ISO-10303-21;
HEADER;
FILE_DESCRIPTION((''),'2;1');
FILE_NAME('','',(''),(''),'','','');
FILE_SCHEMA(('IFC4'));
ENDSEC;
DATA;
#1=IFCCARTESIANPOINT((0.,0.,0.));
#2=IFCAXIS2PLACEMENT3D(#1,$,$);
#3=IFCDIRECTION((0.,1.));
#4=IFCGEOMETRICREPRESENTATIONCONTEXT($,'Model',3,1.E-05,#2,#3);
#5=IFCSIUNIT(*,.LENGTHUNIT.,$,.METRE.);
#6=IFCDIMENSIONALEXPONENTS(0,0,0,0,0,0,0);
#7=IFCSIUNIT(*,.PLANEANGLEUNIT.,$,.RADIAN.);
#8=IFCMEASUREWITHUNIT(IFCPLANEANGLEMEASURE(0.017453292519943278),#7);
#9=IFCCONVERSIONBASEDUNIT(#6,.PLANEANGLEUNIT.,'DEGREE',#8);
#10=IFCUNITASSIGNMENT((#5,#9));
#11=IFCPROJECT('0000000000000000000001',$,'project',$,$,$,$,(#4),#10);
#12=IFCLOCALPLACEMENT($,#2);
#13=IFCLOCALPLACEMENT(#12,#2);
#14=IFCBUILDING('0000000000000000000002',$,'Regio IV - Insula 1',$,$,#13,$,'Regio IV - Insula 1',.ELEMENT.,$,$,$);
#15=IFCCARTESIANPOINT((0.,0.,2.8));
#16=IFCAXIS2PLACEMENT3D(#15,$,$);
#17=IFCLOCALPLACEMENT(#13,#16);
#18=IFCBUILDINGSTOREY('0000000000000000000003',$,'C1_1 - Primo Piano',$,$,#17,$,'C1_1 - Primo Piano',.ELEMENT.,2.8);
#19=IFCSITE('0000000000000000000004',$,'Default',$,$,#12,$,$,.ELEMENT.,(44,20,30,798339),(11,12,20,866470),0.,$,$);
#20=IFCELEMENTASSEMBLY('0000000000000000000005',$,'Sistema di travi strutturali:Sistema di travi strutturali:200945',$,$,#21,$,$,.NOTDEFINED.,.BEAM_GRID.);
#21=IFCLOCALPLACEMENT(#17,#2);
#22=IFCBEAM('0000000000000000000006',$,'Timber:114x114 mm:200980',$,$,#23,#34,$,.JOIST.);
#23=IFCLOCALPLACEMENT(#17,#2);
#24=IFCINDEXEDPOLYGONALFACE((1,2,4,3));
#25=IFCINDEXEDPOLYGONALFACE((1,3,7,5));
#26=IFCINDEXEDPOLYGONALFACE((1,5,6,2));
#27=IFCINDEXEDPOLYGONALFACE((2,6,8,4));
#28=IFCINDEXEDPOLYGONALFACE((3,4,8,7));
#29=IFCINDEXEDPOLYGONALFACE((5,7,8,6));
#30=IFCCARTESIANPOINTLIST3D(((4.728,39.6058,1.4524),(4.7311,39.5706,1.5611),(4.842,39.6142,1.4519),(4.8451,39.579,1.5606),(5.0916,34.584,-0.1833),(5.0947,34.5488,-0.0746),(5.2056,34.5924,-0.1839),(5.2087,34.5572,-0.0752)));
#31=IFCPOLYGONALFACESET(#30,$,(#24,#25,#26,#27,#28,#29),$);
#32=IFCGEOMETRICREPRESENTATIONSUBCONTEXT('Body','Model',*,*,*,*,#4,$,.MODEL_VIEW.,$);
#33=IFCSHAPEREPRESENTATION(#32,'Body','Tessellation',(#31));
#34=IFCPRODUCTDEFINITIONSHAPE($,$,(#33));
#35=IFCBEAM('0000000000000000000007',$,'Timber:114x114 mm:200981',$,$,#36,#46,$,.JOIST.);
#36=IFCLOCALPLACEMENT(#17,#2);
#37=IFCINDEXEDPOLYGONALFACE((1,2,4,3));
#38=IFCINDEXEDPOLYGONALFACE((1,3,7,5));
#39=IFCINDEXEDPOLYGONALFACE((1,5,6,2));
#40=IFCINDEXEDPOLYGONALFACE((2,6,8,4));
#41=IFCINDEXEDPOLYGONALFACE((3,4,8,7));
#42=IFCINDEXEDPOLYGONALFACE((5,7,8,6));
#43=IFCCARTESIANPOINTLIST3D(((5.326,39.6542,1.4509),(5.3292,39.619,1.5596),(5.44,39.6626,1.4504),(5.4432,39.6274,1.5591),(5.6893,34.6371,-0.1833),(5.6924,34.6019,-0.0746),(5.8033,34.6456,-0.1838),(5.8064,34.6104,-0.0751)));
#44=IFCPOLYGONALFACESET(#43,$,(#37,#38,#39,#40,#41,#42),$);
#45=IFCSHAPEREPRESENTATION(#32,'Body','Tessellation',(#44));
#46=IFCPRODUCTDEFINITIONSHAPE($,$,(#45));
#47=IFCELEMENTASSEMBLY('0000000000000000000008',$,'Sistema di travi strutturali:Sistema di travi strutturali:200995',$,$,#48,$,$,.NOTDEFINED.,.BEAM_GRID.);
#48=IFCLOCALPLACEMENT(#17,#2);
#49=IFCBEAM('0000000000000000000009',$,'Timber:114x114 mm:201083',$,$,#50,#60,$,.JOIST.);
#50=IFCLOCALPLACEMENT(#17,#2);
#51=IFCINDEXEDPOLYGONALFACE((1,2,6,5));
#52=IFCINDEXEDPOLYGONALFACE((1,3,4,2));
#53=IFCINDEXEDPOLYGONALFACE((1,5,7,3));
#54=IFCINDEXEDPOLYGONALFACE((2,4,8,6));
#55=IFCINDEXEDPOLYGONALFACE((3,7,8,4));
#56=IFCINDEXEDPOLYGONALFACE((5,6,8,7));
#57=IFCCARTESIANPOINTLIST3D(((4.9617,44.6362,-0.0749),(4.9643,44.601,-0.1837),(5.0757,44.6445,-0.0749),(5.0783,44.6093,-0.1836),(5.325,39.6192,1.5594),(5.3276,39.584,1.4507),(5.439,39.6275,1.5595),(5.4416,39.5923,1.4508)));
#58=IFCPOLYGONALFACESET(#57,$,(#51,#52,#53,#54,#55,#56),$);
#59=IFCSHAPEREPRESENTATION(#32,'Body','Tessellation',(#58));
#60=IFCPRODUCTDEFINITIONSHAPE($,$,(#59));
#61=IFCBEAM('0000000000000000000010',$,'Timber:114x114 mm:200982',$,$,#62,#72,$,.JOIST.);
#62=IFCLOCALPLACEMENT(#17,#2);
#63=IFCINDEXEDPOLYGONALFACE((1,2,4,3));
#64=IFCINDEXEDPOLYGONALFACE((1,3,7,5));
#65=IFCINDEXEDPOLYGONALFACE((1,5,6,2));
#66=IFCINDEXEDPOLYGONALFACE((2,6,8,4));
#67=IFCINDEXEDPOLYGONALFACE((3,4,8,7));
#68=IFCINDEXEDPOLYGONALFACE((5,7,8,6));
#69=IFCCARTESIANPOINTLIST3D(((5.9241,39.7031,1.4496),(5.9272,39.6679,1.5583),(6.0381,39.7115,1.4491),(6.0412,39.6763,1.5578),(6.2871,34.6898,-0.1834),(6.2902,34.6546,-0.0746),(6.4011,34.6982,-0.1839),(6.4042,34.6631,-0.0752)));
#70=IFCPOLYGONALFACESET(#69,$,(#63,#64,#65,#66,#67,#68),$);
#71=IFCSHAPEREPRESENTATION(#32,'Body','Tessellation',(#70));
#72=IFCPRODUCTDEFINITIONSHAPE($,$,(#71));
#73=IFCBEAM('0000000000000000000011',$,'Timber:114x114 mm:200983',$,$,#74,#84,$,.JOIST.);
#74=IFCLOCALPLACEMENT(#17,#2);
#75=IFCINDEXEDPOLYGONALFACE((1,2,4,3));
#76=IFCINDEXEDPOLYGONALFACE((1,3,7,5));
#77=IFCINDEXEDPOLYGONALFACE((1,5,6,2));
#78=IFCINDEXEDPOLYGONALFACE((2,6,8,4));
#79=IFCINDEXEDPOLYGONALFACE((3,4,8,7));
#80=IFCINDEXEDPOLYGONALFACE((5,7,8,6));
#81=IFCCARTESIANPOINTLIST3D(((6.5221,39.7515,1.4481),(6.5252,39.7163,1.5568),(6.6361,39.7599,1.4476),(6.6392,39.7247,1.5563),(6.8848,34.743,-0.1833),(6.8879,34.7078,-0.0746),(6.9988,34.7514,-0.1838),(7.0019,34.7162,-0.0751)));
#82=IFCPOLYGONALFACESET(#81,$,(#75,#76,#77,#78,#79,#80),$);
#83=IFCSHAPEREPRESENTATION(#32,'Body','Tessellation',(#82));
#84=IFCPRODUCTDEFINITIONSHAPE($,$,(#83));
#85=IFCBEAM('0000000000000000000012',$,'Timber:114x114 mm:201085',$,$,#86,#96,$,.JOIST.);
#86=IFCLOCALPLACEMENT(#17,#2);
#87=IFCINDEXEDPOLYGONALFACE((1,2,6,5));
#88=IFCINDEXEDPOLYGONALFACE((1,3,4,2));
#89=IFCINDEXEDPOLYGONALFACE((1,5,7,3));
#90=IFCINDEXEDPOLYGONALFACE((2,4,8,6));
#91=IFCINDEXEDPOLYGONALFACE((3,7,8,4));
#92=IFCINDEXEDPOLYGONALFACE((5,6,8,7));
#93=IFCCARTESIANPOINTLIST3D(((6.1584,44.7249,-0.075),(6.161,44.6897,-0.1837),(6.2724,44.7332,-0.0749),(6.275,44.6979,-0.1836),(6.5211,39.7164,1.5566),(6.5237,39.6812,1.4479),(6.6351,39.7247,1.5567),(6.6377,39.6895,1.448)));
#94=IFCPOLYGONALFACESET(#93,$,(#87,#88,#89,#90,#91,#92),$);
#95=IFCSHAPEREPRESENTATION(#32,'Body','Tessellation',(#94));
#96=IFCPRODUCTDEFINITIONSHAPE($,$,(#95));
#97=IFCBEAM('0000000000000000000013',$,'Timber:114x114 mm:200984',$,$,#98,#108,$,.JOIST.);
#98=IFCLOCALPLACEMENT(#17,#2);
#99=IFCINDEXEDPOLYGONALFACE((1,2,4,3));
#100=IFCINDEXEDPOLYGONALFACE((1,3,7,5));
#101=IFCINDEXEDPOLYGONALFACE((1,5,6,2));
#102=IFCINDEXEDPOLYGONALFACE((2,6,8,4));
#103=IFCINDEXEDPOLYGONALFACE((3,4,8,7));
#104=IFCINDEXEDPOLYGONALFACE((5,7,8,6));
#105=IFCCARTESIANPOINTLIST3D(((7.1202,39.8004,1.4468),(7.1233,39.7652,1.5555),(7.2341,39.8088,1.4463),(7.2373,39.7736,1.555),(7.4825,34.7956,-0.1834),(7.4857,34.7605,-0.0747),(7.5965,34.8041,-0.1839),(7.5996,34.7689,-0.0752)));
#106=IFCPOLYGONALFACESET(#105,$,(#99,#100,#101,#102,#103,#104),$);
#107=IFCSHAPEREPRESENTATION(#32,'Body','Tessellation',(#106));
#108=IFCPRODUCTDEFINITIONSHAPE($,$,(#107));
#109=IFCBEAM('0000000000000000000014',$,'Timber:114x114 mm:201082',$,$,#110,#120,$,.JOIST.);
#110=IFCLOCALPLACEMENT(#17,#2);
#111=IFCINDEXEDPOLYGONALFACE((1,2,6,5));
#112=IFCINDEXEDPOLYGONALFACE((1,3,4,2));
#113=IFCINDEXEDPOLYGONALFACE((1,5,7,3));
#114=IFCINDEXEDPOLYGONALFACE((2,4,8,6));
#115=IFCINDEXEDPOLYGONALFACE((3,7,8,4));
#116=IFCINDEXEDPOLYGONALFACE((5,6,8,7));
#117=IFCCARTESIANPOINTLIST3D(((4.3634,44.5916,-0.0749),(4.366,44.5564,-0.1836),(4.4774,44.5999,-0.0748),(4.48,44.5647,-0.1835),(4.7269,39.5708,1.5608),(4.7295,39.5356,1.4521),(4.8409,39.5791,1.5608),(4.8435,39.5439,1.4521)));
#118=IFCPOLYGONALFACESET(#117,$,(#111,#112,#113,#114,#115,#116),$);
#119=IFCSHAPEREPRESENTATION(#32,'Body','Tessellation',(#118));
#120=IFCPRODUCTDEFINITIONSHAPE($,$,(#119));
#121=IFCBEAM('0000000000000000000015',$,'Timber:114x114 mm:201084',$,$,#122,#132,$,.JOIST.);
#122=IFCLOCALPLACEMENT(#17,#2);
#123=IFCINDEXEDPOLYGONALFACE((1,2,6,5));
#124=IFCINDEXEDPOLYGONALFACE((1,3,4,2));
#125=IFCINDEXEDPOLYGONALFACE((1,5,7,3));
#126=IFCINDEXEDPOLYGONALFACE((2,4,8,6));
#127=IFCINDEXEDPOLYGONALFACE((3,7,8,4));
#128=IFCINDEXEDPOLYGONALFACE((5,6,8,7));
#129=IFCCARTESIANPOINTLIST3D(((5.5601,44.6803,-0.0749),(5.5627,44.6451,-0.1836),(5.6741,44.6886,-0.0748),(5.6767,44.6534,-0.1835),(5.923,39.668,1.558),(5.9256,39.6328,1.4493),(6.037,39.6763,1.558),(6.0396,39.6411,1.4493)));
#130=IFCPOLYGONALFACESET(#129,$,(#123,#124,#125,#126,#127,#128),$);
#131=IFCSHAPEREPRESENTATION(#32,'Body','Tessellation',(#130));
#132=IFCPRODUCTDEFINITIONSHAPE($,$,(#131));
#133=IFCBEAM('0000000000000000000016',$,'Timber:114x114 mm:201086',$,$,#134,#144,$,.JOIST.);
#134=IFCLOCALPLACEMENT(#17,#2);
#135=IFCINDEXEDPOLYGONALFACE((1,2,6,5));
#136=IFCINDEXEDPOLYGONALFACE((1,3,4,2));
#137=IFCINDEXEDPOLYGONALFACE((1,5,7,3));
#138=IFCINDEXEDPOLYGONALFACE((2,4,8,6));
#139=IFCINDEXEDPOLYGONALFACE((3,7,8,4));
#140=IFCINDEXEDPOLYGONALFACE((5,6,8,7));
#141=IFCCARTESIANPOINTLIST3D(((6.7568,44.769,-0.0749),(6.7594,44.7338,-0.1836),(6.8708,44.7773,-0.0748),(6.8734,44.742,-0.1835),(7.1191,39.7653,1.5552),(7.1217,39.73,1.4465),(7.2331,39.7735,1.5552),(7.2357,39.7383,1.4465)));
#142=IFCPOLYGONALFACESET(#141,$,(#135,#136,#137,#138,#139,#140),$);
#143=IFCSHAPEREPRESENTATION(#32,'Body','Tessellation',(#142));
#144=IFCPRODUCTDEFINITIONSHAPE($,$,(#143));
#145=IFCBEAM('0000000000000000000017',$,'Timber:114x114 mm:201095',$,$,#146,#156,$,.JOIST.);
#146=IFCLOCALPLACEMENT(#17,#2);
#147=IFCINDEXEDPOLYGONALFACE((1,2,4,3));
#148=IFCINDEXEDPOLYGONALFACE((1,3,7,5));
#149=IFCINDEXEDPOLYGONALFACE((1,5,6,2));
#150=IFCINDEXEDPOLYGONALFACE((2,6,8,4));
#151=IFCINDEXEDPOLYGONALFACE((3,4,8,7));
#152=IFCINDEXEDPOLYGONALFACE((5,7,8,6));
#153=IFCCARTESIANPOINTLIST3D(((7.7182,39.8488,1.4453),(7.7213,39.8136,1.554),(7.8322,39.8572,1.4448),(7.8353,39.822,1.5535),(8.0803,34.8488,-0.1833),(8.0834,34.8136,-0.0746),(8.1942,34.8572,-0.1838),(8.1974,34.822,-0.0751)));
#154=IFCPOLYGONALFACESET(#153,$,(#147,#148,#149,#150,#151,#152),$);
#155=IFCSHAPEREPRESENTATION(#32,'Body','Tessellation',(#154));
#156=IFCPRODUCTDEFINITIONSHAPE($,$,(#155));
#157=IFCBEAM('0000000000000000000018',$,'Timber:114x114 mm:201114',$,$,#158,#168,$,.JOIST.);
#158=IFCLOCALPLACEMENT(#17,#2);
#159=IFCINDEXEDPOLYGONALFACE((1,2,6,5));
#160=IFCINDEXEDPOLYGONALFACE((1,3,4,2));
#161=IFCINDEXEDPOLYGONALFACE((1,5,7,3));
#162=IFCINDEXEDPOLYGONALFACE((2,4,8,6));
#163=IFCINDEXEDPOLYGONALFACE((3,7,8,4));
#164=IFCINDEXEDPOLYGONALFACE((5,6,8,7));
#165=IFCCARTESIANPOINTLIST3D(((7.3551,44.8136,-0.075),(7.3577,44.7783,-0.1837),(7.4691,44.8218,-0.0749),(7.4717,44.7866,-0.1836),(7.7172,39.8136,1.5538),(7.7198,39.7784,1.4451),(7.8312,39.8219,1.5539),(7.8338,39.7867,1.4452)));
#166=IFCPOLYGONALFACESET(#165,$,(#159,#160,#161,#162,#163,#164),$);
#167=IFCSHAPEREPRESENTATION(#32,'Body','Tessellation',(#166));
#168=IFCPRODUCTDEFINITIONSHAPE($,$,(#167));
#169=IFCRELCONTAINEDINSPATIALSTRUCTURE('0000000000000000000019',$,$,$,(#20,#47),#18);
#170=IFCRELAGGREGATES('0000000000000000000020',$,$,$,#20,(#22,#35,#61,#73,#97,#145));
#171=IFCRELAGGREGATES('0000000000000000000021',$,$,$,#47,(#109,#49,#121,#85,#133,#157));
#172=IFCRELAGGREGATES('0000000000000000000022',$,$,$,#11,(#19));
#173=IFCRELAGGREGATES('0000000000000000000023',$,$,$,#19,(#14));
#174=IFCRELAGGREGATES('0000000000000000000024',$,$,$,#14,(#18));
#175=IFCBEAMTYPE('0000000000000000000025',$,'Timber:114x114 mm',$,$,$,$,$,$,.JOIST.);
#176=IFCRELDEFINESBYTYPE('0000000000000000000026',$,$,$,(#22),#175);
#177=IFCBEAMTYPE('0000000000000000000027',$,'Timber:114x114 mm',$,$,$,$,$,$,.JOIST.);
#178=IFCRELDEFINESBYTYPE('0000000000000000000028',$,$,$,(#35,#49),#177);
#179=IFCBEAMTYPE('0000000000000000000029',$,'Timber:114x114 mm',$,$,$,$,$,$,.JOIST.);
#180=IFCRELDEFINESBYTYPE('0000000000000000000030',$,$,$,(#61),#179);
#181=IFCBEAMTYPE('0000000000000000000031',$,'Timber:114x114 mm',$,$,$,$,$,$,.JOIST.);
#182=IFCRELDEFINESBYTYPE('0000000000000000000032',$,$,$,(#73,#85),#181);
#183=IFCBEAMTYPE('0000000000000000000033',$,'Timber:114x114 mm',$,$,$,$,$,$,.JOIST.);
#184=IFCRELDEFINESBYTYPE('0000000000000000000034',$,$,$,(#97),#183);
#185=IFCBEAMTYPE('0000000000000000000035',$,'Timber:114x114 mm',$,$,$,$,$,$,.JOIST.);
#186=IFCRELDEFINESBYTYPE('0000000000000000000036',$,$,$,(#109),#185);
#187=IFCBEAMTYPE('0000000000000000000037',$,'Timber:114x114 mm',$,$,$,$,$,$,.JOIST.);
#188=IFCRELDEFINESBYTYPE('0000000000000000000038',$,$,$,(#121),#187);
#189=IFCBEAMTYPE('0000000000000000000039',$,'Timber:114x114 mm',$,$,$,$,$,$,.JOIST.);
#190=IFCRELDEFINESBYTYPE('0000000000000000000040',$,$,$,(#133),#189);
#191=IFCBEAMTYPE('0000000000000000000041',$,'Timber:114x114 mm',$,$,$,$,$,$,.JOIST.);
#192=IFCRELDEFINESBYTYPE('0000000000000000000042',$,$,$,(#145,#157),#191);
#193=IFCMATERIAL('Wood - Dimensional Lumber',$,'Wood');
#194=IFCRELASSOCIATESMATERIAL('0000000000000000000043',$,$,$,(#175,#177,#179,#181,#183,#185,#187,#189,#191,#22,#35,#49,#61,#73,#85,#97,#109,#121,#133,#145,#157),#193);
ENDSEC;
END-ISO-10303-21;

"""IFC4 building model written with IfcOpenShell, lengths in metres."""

from ifc_helpers import new_model, entity, si_unit, converted_unit, direction, frame, origin, origin_2d_with_axis, place, context, subcontext, project, spatial, rectangle, extrude, source, transform, mapped, material, material_profile, profile_set, profile_usage, type_object, type_shapes, element, aggregate, save


model = new_model("IFC4")

# Units and contexts
model_context = context("Model", 3, precision=1e-05, world=origin(), true_north=direction((0.0, 1.0)))
body_context = subcontext(model_context, "Body", "Model", "MODEL_VIEW")
ifc_project = project(units=[si_unit("LENGTHUNIT", "METRE"), converted_unit("PLANEANGLEUNIT", "DEGREE", entity("IfcPlaneAngleMeasure", 0.017453292519943278), si_unit("PLANEANGLEUNIT", "RADIAN"), dimensions=[0, 0, 0, 0, 0, 0, 0])], contexts=[model_context])

# Site, building, storey
site_placement = place(None, origin())
site = spatial("IfcSite", under=ifc_project, at=site_placement, Name="Default", CompositionType="ELEMENT", RefLatitude=(44, 20, 30, 798339), RefLongitude=(11, 12, 20, 866470), RefElevation=0.0)
building_placement = place(site_placement, origin())
building = spatial("IfcBuilding", under=site, at=building_placement, Name="Regio IV - Insula 1", LongName="Regio IV - Insula 1", CompositionType="ELEMENT")
storey_placement = place(building_placement, frame((0.0, 0.0, 2.8)))
storey = spatial("IfcBuildingStorey", under=building, at=storey_placement, Name="C1_1 - Primo Piano", LongName="C1_1 - Primo Piano", CompositionType="ELEMENT", Elevation=2.8)

# Element assembly, beams
assembly_1_placement = place(storey_placement, origin())
assembly_1 = element("IfcElementAssembly", 1, at=assembly_1_placement, inside=storey, Name="Sistema di travi strutturali:Sistema di travi strutturali:200945", AssemblyPlace="NOTDEFINED", PredefinedType="BEAM_GRID")
ifc_material = material(Name="Wood - Dimensional Lumber", Category="Wood")
ifc_material_profile = material_profile(ifc_material, rectangle(XDim=5.294, YDim=0.1143, at=origin_2d_with_axis()), Name="114x114 mm")
ifc_profile_set = profile_set([ifc_material_profile], Name="114x114 mm")
ifc_profile_usage = profile_usage(ifc_profile_set, cardinal=8)
beam_type_1 = type_object("IfcBeamType", Name="Timber:114x114 mm", PredefinedType="JOIST", material=ifc_profile_set)
shared_shape_1 = source(origin(), body_context, "Body", "SweptSolid", [
    extrude(rectangle(XDim=5.294, YDim=0.1143, at=origin_2d_with_axis()), frame((0.0, 0.0, -0.0572), z_axis=(0.0, 0.0, 1.0), x_axis=(-1.0, 0.0, 0.0)), (0.0, 0.0, 1.0), 0.1143),
])
type_shapes(beam_type_1, [shared_shape_1])
beam_1_placement = place(assembly_1_placement, frame((4.9684, 37.0815, 0.6886), z_axis=(0.027263, -0.307812, 0.951057), x_axis=(0.068686, -0.948585, -0.308981)))
beam_1 = element("IfcBeam", 2, at=beam_1_placement, type_object=beam_type_1, material=ifc_profile_usage, Name="Timber:114x114 mm:200980", PredefinedType="JOIST", context=body_context, shape_type="MappedRepresentation", body=[
    mapped(shared_shape_1, transform((0.0, 0.0, 0.0), scale=1.0)),
])
beam_type_2 = type_object("IfcBeamType", Name="Timber:114x114 mm", PredefinedType="JOIST", material=ifc_profile_set)
shared_shape_2 = source(origin(), body_context, "Body", "SweptSolid", [
    extrude(rectangle(XDim=5.289, YDim=0.1143, at=origin_2d_with_axis()), frame((0.0, 0.0, -0.0572), z_axis=(0.0, 0.0, 1.0), x_axis=(-1.0, 0.0, 0.0)), (0.0, 0.0, 1.0), 0.1143),
])
type_shapes(beam_type_2, [shared_shape_2])
beam_2_placement = place(assembly_1_placement, frame((5.5662, 37.1323, 0.6879), z_axis=(0.027263, -0.307812, 0.951057), x_axis=(0.068686, -0.948585, -0.308981)))
beam_2 = element("IfcBeam", 3, at=beam_2_placement, type_object=beam_type_2, material=ifc_profile_usage, Name="Timber:114x114 mm:200981", PredefinedType="JOIST", context=body_context, shape_type="MappedRepresentation", body=[
    mapped(shared_shape_2, transform((0.0, 0.0, 0.0), scale=1.0)),
])

# Element assembly, beam
assembly_2_placement = place(storey_placement, origin())
assembly_2 = element("IfcElementAssembly", 4, at=assembly_2_placement, inside=storey, Name="Sistema di travi strutturali:Sistema di travi strutturali:200995", AssemblyPlace="NOTDEFINED", PredefinedType="BEAM_GRID")
beam_3_placement = place(assembly_2_placement, frame((5.2016, 42.1142, 0.6879), z_axis=(-0.022823, 0.308173, 0.951057), x_axis=(0.068685, -0.948573, 0.309017)))
beam_3 = element("IfcBeam", 5, at=beam_3_placement, type_object=beam_type_2, material=ifc_profile_usage, Name="Timber:114x114 mm:201083", PredefinedType="JOIST", context=body_context, shape_type="MappedRepresentation", body=[
    mapped(shared_shape_2, transform((0.0, 0.0, 0.0), scale=1.0)),
])

# Beams
beam_type_3 = type_object("IfcBeamType", Name="Timber:114x114 mm", PredefinedType="JOIST", material=ifc_profile_set)
shared_shape_3 = source(origin(), body_context, "Body", "SweptSolid", [
    extrude(rectangle(XDim=5.285, YDim=0.1143, at=origin_2d_with_axis()), frame((0.0, 0.0, -0.0572), z_axis=(0.0, 0.0, 1.0), x_axis=(-1.0, 0.0, 0.0)), (0.0, 0.0, 1.0), 0.1143),
])
type_shapes(beam_type_3, [shared_shape_3])
beam_4_placement = place(assembly_1_placement, frame((6.1641, 37.1831, 0.6872), z_axis=(0.027263, -0.307812, 0.951057), x_axis=(0.068686, -0.948585, -0.308981)))
beam_4 = element("IfcBeam", 6, at=beam_4_placement, type_object=beam_type_3, material=ifc_profile_usage, Name="Timber:114x114 mm:200982", PredefinedType="JOIST", context=body_context, shape_type="MappedRepresentation", body=[
    mapped(shared_shape_3, transform((0.0, 0.0, 0.0), scale=1.0)),
])
beam_type_4 = type_object("IfcBeamType", Name="Timber:114x114 mm", PredefinedType="JOIST", material=ifc_profile_set)
shared_shape_4 = source(origin(), body_context, "Body", "SweptSolid", [
    extrude(rectangle(XDim=5.28, YDim=0.1143, at=origin_2d_with_axis()), frame((0.0, 0.0, -0.0572), z_axis=(0.0, 0.0, 1.0), x_axis=(-1.0, 0.0, 0.0)), (0.0, 0.0, 1.0), 0.1143),
])
type_shapes(beam_type_4, [shared_shape_4])
beam_5_placement = place(assembly_1_placement, frame((6.762, 37.2338, 0.6865), z_axis=(0.027263, -0.307812, 0.951057), x_axis=(0.068686, -0.948585, -0.308981)))
beam_5 = element("IfcBeam", 7, at=beam_5_placement, type_object=beam_type_4, material=ifc_profile_usage, Name="Timber:114x114 mm:200983", PredefinedType="JOIST", context=body_context, shape_type="MappedRepresentation", body=[
    mapped(shared_shape_4, transform((0.0, 0.0, 0.0), scale=1.0)),
])
beam_6_placement = place(assembly_2_placement, frame((6.398, 42.2072, 0.6865), z_axis=(-0.022823, 0.308173, 0.951057), x_axis=(0.068685, -0.948573, 0.309017)))
beam_6 = element("IfcBeam", 8, at=beam_6_placement, type_object=beam_type_4, material=ifc_profile_usage, Name="Timber:114x114 mm:201085", PredefinedType="JOIST", context=body_context, shape_type="MappedRepresentation", body=[
    mapped(shared_shape_4, transform((0.0, 0.0, 0.0), scale=1.0)),
])
beam_type_5 = type_object("IfcBeamType", Name="Timber:114x114 mm", PredefinedType="JOIST", material=ifc_profile_set)
shared_shape_5 = source(origin(), body_context, "Body", "SweptSolid", [
    extrude(rectangle(XDim=5.276, YDim=0.1143, at=origin_2d_with_axis()), frame((0.0, 0.0, -0.0572), z_axis=(0.0, 0.0, 1.0), x_axis=(-1.0, 0.0, 0.0)), (0.0, 0.0, 1.0), 0.1143),
])
type_shapes(beam_type_5, [shared_shape_5])
beam_7_placement = place(assembly_1_placement, frame((7.3599, 37.2846, 0.6858), z_axis=(0.027263, -0.307812, 0.951057), x_axis=(0.068686, -0.948585, -0.308981)))
beam_7 = element("IfcBeam", 9, at=beam_7_placement, type_object=beam_type_5, material=ifc_profile_usage, Name="Timber:114x114 mm:200984", PredefinedType="JOIST", context=body_context, shape_type="MappedRepresentation", body=[
    mapped(shared_shape_5, transform((0.0, 0.0, 0.0), scale=1.0)),
])
beam_type_6 = type_object("IfcBeamType", Name="Timber:114x114 mm", PredefinedType="JOIST", material=ifc_profile_set)
shared_shape_6 = source(origin(), body_context, "Body", "SweptSolid", [
    extrude(rectangle(XDim=5.293, YDim=0.1143, at=origin_2d_with_axis()), frame((0.0, 0.0, -0.0572), z_axis=(0.0, 0.0, 1.0), x_axis=(-1.0, 0.0, 0.0)), (0.0, 0.0, 1.0), 0.1143),
])
type_shapes(beam_type_6, [shared_shape_6])
beam_8_placement = place(assembly_2_placement, frame((4.6034, 42.0678, 0.6886), z_axis=(-0.022823, 0.308173, 0.951057), x_axis=(0.068685, -0.948573, 0.309017)))
beam_8 = element("IfcBeam", 10, at=beam_8_placement, type_object=beam_type_6, material=ifc_profile_usage, Name="Timber:114x114 mm:201082", PredefinedType="JOIST", context=body_context, shape_type="MappedRepresentation", body=[
    mapped(shared_shape_6, transform((0.0, 0.0, 0.0), scale=1.0)),
])
beam_type_7 = type_object("IfcBeamType", Name="Timber:114x114 mm", PredefinedType="JOIST", material=ifc_profile_set)
shared_shape_7 = source(origin(), body_context, "Body", "SweptSolid", [
    extrude(rectangle(XDim=5.284, YDim=0.1143, at=origin_2d_with_axis()), frame((0.0, 0.0, -0.0572), z_axis=(0.0, 0.0, 1.0), x_axis=(-1.0, 0.0, 0.0)), (0.0, 0.0, 1.0), 0.1143),
])
type_shapes(beam_type_7, [shared_shape_7])
beam_9_placement = place(assembly_2_placement, frame((5.7998, 42.1607, 0.6872), z_axis=(-0.022823, 0.308173, 0.951057), x_axis=(0.068685, -0.948573, 0.309017)))
beam_9 = element("IfcBeam", 11, at=beam_9_placement, type_object=beam_type_7, material=ifc_profile_usage, Name="Timber:114x114 mm:201084", PredefinedType="JOIST", context=body_context, shape_type="MappedRepresentation", body=[
    mapped(shared_shape_7, transform((0.0, 0.0, 0.0), scale=1.0)),
])
beam_type_8 = type_object("IfcBeamType", Name="Timber:114x114 mm", PredefinedType="JOIST", material=ifc_profile_set)
shared_shape_8 = source(origin(), body_context, "Body", "SweptSolid", [
    extrude(rectangle(XDim=5.275, YDim=0.1143, at=origin_2d_with_axis()), frame((0.0, 0.0, -0.0572), z_axis=(0.0, 0.0, 1.0), x_axis=(-1.0, 0.0, 0.0)), (0.0, 0.0, 1.0), 0.1143),
])
type_shapes(beam_type_8, [shared_shape_8])
beam_10_placement = place(assembly_2_placement, frame((6.9963, 42.2536, 0.6858), z_axis=(-0.022823, 0.308173, 0.951057), x_axis=(0.068685, -0.948573, 0.309017)))
beam_10 = element("IfcBeam", 12, at=beam_10_placement, type_object=beam_type_8, material=ifc_profile_usage, Name="Timber:114x114 mm:201086", PredefinedType="JOIST", context=body_context, shape_type="MappedRepresentation", body=[
    mapped(shared_shape_8, transform((0.0, 0.0, 0.0), scale=1.0)),
])
beam_type_9 = type_object("IfcBeamType", Name="Timber:114x114 mm", PredefinedType="JOIST", material=ifc_profile_set)
shared_shape_9 = source(origin(), body_context, "Body", "SweptSolid", [
    extrude(rectangle(XDim=5.271, YDim=0.1143, at=origin_2d_with_axis()), frame((0.0, 0.0, -0.0572), z_axis=(0.0, 0.0, 1.0), x_axis=(-1.0, 0.0, 0.0)), (0.0, 0.0, 1.0), 0.1143),
])
type_shapes(beam_type_9, [shared_shape_9])
beam_11_placement = place(assembly_1_placement, frame((7.9578, 37.3354, 0.6851), z_axis=(0.027263, -0.307812, 0.951057), x_axis=(0.068686, -0.948585, -0.308981)))
beam_11 = element("IfcBeam", 13, at=beam_11_placement, type_object=beam_type_9, material=ifc_profile_usage, Name="Timber:114x114 mm:201095", PredefinedType="JOIST", context=body_context, shape_type="MappedRepresentation", body=[
    mapped(shared_shape_9, transform((0.0, 0.0, 0.0), scale=1.0)),
])
beam_12_placement = place(assembly_2_placement, frame((7.5945, 42.3001, 0.6851), z_axis=(-0.022823, 0.308173, 0.951057), x_axis=(0.068685, -0.948573, 0.309017)))
beam_12 = element("IfcBeam", 14, at=beam_12_placement, type_object=beam_type_9, material=ifc_profile_usage, Name="Timber:114x114 mm:201114", PredefinedType="JOIST", context=body_context, shape_type="MappedRepresentation", body=[
    mapped(shared_shape_9, transform((0.0, 0.0, 0.0), scale=1.0)),
])
aggregate(assembly_1, [beam_1, beam_2, beam_4, beam_5, beam_7, beam_11])
aggregate(assembly_2, [beam_8, beam_3, beam_9, beam_6, beam_10, beam_12])

save(model, "model.ifc")
